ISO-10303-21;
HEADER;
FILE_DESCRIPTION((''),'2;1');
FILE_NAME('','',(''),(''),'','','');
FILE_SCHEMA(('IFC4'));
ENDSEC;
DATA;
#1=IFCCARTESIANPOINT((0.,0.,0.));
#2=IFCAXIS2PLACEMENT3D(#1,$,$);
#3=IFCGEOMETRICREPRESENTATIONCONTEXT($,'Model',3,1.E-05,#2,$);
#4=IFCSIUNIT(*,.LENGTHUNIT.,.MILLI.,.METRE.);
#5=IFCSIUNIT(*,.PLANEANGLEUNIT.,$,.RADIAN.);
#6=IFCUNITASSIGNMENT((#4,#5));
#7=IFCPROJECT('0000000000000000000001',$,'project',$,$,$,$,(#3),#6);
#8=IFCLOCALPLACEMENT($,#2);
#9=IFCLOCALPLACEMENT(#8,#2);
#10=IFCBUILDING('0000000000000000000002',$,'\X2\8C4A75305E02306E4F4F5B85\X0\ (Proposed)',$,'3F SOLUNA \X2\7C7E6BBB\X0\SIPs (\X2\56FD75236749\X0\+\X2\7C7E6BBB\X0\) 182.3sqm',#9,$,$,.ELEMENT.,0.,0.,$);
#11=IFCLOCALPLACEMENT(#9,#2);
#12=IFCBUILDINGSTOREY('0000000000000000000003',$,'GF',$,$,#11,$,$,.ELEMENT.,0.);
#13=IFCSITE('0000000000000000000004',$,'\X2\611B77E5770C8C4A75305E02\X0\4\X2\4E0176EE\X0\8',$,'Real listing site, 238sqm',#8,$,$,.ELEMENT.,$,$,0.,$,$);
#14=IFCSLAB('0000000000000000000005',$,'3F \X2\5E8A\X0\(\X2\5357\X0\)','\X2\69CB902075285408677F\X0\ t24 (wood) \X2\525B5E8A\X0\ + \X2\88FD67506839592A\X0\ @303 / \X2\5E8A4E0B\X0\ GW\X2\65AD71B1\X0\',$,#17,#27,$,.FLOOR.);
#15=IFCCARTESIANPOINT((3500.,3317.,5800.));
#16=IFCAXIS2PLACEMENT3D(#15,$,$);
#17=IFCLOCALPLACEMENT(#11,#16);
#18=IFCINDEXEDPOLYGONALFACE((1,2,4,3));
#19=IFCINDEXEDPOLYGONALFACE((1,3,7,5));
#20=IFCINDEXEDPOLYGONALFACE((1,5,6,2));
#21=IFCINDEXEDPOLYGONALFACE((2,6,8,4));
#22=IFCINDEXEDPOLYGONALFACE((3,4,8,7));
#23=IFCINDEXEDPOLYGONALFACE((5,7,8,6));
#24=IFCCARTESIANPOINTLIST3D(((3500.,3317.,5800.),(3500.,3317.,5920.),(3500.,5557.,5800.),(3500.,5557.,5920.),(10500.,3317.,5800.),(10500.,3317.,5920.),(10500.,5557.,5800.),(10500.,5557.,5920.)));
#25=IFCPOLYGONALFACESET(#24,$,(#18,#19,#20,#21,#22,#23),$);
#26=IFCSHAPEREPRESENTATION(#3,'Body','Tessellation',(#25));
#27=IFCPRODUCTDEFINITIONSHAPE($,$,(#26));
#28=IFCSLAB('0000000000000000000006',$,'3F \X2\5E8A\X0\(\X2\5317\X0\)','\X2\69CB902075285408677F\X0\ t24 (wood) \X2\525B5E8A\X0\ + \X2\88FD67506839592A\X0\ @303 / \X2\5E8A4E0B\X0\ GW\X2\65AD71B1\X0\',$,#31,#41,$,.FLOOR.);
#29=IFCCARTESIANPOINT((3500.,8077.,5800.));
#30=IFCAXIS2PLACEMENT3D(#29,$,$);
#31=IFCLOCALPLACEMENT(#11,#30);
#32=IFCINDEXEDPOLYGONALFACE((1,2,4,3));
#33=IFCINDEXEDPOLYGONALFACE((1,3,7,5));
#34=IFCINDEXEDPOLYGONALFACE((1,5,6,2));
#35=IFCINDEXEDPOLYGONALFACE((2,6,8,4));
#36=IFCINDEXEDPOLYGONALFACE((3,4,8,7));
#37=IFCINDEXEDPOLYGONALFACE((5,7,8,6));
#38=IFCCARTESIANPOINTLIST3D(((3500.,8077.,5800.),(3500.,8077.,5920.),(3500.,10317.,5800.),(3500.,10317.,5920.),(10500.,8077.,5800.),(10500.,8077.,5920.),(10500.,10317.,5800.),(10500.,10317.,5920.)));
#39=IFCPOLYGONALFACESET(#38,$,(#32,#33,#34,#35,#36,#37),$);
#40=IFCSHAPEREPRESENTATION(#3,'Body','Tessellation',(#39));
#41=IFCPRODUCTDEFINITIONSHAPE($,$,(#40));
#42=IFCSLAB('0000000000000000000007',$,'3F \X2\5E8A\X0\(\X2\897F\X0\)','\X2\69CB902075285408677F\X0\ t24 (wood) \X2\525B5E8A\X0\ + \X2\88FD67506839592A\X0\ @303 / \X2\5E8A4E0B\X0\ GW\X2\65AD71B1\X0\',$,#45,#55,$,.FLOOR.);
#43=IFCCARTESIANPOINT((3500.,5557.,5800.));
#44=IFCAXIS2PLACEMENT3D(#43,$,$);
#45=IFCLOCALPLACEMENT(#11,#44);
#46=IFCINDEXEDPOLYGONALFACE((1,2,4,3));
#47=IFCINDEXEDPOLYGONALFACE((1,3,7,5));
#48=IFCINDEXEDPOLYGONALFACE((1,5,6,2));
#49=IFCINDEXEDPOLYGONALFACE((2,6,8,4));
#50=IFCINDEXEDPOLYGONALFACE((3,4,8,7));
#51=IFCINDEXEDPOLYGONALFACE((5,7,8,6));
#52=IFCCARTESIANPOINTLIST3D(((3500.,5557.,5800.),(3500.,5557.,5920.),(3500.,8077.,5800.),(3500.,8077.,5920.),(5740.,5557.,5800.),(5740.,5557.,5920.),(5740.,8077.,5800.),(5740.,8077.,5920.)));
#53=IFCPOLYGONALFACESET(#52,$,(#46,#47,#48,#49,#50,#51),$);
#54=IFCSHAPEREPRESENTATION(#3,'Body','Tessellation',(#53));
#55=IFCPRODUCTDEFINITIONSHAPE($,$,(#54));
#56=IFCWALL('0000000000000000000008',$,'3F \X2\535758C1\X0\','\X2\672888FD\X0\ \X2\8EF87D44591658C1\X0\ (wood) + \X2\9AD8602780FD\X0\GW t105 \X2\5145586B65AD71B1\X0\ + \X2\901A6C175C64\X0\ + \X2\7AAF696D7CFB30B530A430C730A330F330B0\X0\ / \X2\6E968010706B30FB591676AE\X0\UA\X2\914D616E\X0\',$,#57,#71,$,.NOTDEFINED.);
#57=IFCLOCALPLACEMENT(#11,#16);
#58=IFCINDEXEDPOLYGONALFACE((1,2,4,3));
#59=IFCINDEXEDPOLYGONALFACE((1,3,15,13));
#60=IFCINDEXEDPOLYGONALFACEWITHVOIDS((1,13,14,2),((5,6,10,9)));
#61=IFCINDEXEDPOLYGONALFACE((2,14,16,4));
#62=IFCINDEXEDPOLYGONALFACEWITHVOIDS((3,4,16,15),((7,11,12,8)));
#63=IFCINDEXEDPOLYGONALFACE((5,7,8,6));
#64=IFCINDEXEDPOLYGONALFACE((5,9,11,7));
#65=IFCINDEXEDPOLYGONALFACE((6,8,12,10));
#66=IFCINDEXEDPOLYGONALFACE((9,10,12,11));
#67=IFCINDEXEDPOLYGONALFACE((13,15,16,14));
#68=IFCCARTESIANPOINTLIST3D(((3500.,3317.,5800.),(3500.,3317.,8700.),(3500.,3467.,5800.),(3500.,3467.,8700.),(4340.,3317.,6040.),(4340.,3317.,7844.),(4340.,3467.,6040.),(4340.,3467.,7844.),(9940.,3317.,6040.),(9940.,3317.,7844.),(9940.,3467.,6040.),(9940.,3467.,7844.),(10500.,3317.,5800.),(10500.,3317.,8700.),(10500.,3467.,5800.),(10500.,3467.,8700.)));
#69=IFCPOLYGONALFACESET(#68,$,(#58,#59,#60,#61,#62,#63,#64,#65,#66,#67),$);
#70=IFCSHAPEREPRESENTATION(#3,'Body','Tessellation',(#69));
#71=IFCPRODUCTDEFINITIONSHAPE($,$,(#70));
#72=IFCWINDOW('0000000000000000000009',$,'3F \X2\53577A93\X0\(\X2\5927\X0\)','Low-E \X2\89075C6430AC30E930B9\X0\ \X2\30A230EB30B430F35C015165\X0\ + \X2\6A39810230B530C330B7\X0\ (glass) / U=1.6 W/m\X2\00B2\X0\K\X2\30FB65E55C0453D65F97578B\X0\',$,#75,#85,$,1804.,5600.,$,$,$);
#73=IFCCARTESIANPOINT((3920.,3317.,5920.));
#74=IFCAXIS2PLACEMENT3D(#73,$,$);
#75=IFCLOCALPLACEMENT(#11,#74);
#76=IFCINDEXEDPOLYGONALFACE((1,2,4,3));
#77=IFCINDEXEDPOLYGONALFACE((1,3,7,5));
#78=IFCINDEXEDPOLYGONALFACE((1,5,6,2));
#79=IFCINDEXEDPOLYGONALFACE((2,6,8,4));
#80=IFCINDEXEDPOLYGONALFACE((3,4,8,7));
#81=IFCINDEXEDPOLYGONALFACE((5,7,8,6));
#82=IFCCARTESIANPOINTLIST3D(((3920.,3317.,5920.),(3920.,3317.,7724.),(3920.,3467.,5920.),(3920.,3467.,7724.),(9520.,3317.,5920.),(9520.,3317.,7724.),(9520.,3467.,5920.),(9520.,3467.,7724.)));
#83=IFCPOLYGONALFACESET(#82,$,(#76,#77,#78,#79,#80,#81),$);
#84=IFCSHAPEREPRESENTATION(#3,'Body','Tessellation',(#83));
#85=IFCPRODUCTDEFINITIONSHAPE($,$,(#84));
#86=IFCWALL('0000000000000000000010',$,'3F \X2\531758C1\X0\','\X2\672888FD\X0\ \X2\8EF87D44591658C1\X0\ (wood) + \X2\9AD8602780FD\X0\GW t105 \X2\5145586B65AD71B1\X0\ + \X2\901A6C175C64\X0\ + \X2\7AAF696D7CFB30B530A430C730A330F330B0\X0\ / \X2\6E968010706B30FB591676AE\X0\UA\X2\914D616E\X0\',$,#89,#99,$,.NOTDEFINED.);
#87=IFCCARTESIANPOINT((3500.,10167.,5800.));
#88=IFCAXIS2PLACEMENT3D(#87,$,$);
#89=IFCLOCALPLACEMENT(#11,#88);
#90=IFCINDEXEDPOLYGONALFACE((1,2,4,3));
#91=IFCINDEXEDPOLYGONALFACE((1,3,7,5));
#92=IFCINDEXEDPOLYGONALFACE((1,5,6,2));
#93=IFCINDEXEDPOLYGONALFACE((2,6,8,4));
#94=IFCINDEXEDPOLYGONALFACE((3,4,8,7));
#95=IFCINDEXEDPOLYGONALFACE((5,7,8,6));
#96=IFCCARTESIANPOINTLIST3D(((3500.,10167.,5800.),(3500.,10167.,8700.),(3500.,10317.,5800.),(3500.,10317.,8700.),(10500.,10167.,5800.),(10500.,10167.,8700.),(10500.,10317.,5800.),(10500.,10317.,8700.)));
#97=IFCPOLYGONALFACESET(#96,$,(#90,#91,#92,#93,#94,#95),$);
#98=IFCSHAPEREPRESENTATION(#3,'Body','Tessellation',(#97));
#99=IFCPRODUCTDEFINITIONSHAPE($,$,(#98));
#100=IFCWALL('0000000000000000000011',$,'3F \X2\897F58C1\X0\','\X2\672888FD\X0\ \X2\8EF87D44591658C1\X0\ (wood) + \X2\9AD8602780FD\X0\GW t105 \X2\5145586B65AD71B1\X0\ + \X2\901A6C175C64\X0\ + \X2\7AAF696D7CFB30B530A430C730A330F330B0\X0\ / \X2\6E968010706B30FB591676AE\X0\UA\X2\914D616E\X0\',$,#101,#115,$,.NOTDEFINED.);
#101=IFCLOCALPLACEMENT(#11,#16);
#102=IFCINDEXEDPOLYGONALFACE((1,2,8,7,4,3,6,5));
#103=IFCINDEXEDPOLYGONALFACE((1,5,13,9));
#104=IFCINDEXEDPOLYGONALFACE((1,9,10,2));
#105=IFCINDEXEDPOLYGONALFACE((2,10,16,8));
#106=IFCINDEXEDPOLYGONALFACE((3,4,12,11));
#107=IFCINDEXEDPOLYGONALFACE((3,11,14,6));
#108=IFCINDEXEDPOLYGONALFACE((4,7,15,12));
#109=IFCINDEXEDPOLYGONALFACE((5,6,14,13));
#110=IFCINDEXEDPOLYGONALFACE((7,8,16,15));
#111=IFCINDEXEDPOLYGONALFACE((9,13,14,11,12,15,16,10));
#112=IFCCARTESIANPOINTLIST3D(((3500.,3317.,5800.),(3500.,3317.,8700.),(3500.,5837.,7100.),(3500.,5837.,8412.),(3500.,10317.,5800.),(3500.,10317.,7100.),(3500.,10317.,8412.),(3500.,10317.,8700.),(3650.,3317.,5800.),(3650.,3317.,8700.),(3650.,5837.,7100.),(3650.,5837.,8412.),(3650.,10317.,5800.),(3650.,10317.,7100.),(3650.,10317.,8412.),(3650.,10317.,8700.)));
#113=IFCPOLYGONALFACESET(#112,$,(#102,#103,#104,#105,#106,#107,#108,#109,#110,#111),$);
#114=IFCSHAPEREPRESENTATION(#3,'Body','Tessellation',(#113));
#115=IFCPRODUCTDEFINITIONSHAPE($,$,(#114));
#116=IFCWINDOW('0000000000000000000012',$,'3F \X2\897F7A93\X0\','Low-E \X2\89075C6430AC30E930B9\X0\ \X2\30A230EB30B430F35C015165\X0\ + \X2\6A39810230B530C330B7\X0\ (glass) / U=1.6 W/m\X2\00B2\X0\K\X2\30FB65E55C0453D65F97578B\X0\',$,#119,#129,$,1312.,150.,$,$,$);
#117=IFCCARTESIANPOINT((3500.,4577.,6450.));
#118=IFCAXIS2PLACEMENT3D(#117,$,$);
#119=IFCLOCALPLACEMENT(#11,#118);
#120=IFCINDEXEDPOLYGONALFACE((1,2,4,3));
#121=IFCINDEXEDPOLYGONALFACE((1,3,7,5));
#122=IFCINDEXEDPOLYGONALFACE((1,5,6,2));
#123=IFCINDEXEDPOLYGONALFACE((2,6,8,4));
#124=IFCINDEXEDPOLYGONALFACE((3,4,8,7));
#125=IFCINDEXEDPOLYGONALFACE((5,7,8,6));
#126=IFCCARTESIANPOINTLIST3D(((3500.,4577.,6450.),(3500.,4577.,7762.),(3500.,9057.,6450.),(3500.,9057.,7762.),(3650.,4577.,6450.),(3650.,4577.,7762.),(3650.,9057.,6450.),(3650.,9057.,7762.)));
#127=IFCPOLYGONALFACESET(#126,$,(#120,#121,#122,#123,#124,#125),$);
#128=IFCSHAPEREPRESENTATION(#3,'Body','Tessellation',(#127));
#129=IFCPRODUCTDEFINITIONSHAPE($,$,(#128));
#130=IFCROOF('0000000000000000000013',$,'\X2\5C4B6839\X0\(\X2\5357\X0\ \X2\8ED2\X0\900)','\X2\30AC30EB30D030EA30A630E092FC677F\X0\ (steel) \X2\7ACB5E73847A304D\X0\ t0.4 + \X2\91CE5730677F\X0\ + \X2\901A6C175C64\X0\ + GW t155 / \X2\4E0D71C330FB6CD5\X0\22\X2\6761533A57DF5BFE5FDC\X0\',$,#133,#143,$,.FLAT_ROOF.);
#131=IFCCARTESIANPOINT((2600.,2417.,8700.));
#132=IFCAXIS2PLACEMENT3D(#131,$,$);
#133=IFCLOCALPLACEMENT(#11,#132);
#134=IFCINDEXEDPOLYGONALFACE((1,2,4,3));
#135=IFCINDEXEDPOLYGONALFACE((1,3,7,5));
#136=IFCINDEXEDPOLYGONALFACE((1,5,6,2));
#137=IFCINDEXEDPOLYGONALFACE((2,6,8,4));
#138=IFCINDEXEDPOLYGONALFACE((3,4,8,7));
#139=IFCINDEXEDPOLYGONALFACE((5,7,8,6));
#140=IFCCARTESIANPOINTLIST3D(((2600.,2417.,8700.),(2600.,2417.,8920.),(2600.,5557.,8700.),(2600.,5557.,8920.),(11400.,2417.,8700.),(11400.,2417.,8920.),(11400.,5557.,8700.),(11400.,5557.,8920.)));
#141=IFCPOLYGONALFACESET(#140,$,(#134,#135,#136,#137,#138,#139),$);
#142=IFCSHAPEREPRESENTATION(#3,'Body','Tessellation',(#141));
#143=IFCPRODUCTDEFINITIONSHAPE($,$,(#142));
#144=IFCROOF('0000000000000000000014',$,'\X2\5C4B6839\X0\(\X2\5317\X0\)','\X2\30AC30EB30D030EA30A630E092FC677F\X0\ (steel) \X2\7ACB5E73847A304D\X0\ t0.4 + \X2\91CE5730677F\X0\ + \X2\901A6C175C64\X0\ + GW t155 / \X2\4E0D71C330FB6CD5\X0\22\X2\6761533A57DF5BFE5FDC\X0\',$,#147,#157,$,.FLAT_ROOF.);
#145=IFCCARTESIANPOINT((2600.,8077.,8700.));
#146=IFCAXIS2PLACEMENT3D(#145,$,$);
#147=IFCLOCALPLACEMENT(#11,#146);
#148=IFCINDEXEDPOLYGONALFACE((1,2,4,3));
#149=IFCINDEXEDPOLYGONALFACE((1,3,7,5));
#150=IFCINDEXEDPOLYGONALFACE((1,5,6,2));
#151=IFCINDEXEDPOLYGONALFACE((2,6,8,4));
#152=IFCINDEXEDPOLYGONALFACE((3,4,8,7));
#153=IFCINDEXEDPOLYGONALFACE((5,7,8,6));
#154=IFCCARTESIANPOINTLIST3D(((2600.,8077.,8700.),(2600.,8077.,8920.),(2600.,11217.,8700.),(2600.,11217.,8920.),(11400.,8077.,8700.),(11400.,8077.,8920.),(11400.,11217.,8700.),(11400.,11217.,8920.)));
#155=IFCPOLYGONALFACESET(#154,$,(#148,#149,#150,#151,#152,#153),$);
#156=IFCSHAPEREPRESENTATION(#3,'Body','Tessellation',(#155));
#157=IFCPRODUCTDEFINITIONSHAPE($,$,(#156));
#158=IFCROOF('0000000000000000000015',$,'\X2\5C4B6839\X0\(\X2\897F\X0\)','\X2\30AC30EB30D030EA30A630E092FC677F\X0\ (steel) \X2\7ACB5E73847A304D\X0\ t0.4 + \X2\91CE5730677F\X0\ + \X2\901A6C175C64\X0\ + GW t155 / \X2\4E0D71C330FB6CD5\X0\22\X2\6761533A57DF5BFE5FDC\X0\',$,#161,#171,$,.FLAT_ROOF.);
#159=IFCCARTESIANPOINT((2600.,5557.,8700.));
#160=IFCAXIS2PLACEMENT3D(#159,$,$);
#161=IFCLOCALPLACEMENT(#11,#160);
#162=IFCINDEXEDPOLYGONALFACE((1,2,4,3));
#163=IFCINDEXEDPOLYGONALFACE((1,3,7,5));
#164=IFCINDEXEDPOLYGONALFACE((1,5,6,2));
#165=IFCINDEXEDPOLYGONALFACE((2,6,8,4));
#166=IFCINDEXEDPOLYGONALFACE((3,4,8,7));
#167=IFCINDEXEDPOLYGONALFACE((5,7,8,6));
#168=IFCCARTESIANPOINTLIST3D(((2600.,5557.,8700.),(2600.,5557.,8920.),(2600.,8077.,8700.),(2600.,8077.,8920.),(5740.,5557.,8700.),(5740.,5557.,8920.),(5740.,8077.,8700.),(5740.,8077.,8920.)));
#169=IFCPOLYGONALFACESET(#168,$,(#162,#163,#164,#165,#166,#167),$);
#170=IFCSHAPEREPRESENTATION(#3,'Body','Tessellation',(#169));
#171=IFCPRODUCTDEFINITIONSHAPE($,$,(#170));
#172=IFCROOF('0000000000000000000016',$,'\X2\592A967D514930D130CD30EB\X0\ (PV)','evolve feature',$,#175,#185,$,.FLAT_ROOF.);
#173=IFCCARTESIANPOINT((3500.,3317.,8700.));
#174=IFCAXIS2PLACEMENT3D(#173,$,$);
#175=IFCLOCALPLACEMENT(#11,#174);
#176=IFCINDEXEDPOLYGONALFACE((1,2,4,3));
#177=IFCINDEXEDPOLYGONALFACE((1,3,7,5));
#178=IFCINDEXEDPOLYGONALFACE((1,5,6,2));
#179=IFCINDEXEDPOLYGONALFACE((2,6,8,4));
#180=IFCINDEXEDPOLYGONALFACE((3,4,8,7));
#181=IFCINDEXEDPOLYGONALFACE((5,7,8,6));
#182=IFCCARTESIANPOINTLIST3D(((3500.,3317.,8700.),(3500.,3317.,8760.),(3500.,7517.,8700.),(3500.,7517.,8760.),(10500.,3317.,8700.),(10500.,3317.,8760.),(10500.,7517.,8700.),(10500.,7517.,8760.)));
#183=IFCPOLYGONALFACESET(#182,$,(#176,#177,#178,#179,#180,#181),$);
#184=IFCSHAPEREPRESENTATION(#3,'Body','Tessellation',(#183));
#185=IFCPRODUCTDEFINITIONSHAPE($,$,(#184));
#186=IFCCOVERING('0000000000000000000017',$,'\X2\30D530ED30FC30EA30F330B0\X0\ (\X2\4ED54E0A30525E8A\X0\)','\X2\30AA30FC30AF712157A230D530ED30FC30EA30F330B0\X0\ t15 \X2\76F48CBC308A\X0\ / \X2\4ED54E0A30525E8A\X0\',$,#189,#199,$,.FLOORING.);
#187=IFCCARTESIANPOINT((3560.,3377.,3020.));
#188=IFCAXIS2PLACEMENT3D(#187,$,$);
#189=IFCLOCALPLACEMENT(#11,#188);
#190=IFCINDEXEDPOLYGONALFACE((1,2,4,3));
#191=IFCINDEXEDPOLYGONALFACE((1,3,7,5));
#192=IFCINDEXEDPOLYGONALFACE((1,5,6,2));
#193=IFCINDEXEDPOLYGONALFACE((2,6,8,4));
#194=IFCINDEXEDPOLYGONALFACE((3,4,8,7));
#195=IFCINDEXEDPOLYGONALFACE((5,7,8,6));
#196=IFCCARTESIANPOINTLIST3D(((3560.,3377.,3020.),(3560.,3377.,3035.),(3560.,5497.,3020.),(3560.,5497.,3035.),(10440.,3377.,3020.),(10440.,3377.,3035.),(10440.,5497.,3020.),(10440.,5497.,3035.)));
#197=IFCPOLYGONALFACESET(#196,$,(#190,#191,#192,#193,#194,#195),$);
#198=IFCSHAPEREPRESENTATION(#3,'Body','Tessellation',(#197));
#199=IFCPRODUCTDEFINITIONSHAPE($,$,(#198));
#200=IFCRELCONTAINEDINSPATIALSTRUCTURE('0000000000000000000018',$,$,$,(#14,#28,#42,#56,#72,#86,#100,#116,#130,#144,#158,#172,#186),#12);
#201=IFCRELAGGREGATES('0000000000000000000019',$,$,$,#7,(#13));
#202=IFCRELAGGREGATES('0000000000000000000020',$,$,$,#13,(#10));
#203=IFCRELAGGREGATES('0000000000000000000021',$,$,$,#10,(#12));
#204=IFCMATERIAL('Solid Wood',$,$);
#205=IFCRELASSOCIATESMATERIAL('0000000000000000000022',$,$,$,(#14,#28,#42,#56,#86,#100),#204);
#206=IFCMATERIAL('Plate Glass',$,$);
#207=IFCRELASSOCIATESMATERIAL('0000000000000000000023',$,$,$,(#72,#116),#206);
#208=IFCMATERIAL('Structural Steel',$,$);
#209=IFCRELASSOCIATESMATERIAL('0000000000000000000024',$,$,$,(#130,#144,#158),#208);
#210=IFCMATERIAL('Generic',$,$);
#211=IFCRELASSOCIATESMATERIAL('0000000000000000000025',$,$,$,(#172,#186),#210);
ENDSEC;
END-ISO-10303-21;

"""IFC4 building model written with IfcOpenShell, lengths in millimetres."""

from ifc_helpers import new_model, si_unit, frame, frame_2d, origin, place, context, project, spatial, rectangle, extrude, material, element, fill, save


model = new_model("IFC4")

# Units and contexts
model_context = context("Model", 3, precision=1e-05, world=origin())
ifc_project = project(units=[si_unit("LENGTHUNIT", "METRE", prefix="MILLI"), si_unit("PLANEANGLEUNIT", "RADIAN")], contexts=[model_context])

# Site, building, storey
site_placement = place(None, origin())
site = spatial("IfcSite", under=ifc_project, at=site_placement, Name="愛知県豊田市4丁目8", ObjectType="Real listing site, 238sqm", CompositionType="ELEMENT", RefElevation=0.0)
building_placement = place(site_placement, origin())
building = spatial("IfcBuilding", under=site, at=building_placement, Name="豊田市の住宅 (Proposed)", ObjectType="3F SOLUNA 籾殻SIPs (国産杉+籾殻) 182.3sqm", CompositionType="ELEMENT", ElevationOfRefHeight=0.0, ElevationOfTerrain=0.0)
storey_placement = place(building_placement, origin())
storey = spatial("IfcBuildingStorey", under=building, at=storey_placement, Name="GF", CompositionType="ELEMENT", Elevation=0.0)

# Slabs
ifc_material_1 = material(Name="Solid Wood")
slab_1_placement = place(storey_placement, frame((3500.0, 3317.0, 5800.0)))
element("IfcSlab", 1, at=slab_1_placement, inside=storey, material=ifc_material_1, Name="3F 床(南)", Description="構造用合板 t24 (wood) 剛床 + 製材根太 @303 / 床下 GW断熱", PredefinedType="FLOOR", context=model_context, shape_type="SweptSolid", body=[
    extrude(rectangle(XDim=7000.0, YDim=2240.0, at=frame_2d((3500.0, 1120.0))), frame((3500.0, 3317.0, 5800.0)), (0.0, 0.0, 1.0), 120.0),
])
slab_2_placement = place(storey_placement, frame((3500.0, 8077.0, 5800.0)))
element("IfcSlab", 2, at=slab_2_placement, inside=storey, material=ifc_material_1, Name="3F 床(北)", Description="構造用合板 t24 (wood) 剛床 + 製材根太 @303 / 床下 GW断熱", PredefinedType="FLOOR", context=model_context, shape_type="SweptSolid", body=[
    extrude(rectangle(XDim=7000.0, YDim=2240.0, at=frame_2d((3500.0, 1120.0))), frame((3500.0, 8077.0, 5800.0)), (0.0, 0.0, 1.0), 120.0),
])
slab_3_placement = place(storey_placement, frame((3500.0, 5557.0, 5800.0)))
element("IfcSlab", 3, at=slab_3_placement, inside=storey, material=ifc_material_1, Name="3F 床(西)", Description="構造用合板 t24 (wood) 剛床 + 製材根太 @303 / 床下 GW断熱", PredefinedType="FLOOR", context=model_context, shape_type="SweptSolid", body=[
    extrude(rectangle(XDim=2240.0, YDim=2520.0, at=frame_2d((1120.0, 1260.0))), frame((3500.0, 5557.0, 5800.0)), (0.0, 0.0, 1.0), 120.0),
])

# Wall, opening, window
wall_1_placement = place(storey_placement, frame((3500.0, 3317.0, 5800.0)))
wall_1 = element("IfcWall", 4, at=wall_1_placement, inside=storey, material=ifc_material_1, Name="3F 南壁", Description="木製 軸組外壁 (wood) + 高性能GW t105 充填断熱 + 通気層 + 窯業系サイディング / 準耐火・外皮UA配慮", PredefinedType="NOTDEFINED", context=model_context, shape_type="SweptSolid", body=[
    extrude(rectangle(XDim=7000.0, YDim=150.0, at=frame_2d((3500.0, 75.0))), frame((3500.0, 3317.0, 5800.0)), (0.0, 0.0, 1.0), 2900.0),
])
opening_1_placement = place(storey_placement, frame((3920.0, 3317.0, 5920.0)))
opening_1 = element("IfcOpeningElement", 5, at=opening_1_placement, cuts=wall_1, PredefinedType="NOTDEFINED", context=model_context, shape_type="SweptSolid", body=[
    extrude(rectangle(XDim=5600.0, YDim=150.0, at=frame_2d((2800.0, 75.0))), frame((3920.0, 3317.0, 5920.0)), (0.0, 0.0, 1.0), 1804.0),
])
ifc_material_2 = material(Name="Plate Glass")
window_1_placement = place(storey_placement, frame((3920.0, 3317.0, 5920.0)))
window_1 = element("IfcWindow", 6, at=window_1_placement, inside=storey, material=ifc_material_2, Name="3F 南窓(大)", Description="Low-E 複層ガラス アルゴン封入 + 樹脂サッシ (glass) / U=1.6 W/m²K・日射取得型", OverallHeight=1804.0, OverallWidth=5600.0, context=model_context, shape_type="SweptSolid", body=[
    extrude(rectangle(XDim=5600.0, YDim=150.0, at=frame_2d((2800.0, 75.0))), frame((3920.0, 3317.0, 5920.0)), (0.0, 0.0, 1.0), 1804.0),
])
fill(opening_1, window_1)

# Wall
wall_2_placement = place(storey_placement, frame((3500.0, 10167.0, 5800.0)))
element("IfcWall", 7, at=wall_2_placement, inside=storey, material=ifc_material_1, Name="3F 北壁", Description="木製 軸組外壁 (wood) + 高性能GW t105 充填断熱 + 通気層 + 窯業系サイディング / 準耐火・外皮UA配慮", PredefinedType="NOTDEFINED", context=model_context, shape_type="SweptSolid", body=[
    extrude(rectangle(XDim=7000.0, YDim=150.0, at=frame_2d((3500.0, 75.0))), frame((3500.0, 10167.0, 5800.0)), (0.0, 0.0, 1.0), 2900.0),
])

# Wall, opening, window
wall_3_placement = place(storey_placement, frame((3500.0, 3317.0, 5800.0)))
wall_3 = element("IfcWall", 8, at=wall_3_placement, inside=storey, material=ifc_material_1, Name="3F 西壁", Description="木製 軸組外壁 (wood) + 高性能GW t105 充填断熱 + 通気層 + 窯業系サイディング / 準耐火・外皮UA配慮", PredefinedType="NOTDEFINED", context=model_context, shape_type="SweptSolid", body=[
    extrude(rectangle(XDim=150.0, YDim=7000.0, at=frame_2d((75.0, 3500.0))), frame((3500.0, 3317.0, 5800.0)), (0.0, 0.0, 1.0), 2900.0),
])
opening_2_placement = place(storey_placement, frame((3500.0, 4577.0, 6450.0)))
opening_2 = element("IfcOpeningElement", 9, at=opening_2_placement, cuts=wall_3, PredefinedType="NOTDEFINED", context=model_context, shape_type="SweptSolid", body=[
    extrude(rectangle(XDim=150.0, YDim=4480.0, at=frame_2d((75.0, 2240.0))), frame((3500.0, 4577.0, 6450.0)), (0.0, 0.0, 1.0), 1312.0),
])
window_2_placement = place(storey_placement, frame((3500.0, 4577.0, 6450.0)))
window_2 = element("IfcWindow", 10, at=window_2_placement, inside=storey, material=ifc_material_2, Name="3F 西窓", Description="Low-E 複層ガラス アルゴン封入 + 樹脂サッシ (glass) / U=1.6 W/m²K・日射取得型", OverallHeight=1312.0, OverallWidth=150.0, context=model_context, shape_type="SweptSolid", body=[
    extrude(rectangle(XDim=150.0, YDim=4480.0, at=frame_2d((75.0, 2240.0))), frame((3500.0, 4577.0, 6450.0)), (0.0, 0.0, 1.0), 1312.0),
])
fill(opening_2, window_2)

# Roofs
ifc_material_3 = material(Name="Structural Steel")
roof_1_placement = place(storey_placement, frame((2600.0, 2417.0, 8700.0)))
element("IfcRoof", 11, at=roof_1_placement, inside=storey, material=ifc_material_3, Name="屋根(南 軒900)", Description="ガルバリウム鋼板 (steel) 立平葺き t0.4 + 野地板 + 通気層 + GW t155 / 不燃・法22条区域対応", PredefinedType="FLAT_ROOF", context=model_context, shape_type="SweptSolid", body=[
    extrude(rectangle(XDim=8800.0, YDim=3140.0, at=frame_2d((4400.0, 1570.0))), frame((2600.0, 2417.0, 8700.0)), (0.0, 0.0, 1.0), 220.0),
])
roof_2_placement = place(storey_placement, frame((2600.0, 8077.0, 8700.0)))
element("IfcRoof", 12, at=roof_2_placement, inside=storey, material=ifc_material_3, Name="屋根(北)", Description="ガルバリウム鋼板 (steel) 立平葺き t0.4 + 野地板 + 通気層 + GW t155 / 不燃・法22条区域対応", PredefinedType="FLAT_ROOF", context=model_context, shape_type="SweptSolid", body=[
    extrude(rectangle(XDim=8800.0, YDim=3140.0, at=frame_2d((4400.0, 1570.0))), frame((2600.0, 8077.0, 8700.0)), (0.0, 0.0, 1.0), 220.0),
])
roof_3_placement = place(storey_placement, frame((2600.0, 5557.0, 8700.0)))
element("IfcRoof", 13, at=roof_3_placement, inside=storey, material=ifc_material_3, Name="屋根(西)", Description="ガルバリウム鋼板 (steel) 立平葺き t0.4 + 野地板 + 通気層 + GW t155 / 不燃・法22条区域対応", PredefinedType="FLAT_ROOF", context=model_context, shape_type="SweptSolid", body=[
    extrude(rectangle(XDim=3140.0, YDim=2520.0, at=frame_2d((1570.0, 1260.0))), frame((2600.0, 5557.0, 8700.0)), (0.0, 0.0, 1.0), 220.0),
])
ifc_material_4 = material(Name="Generic")
roof_4_placement = place(storey_placement, frame((3500.0, 3317.0, 8700.0)))
element("IfcRoof", 14, at=roof_4_placement, inside=storey, material=ifc_material_4, Name="太陽光パネル (PV)", Description="evolve feature", PredefinedType="FLAT_ROOF", context=model_context, shape_type="SweptSolid", body=[
    extrude(rectangle(XDim=7000.0, YDim=4200.0, at=frame_2d((3500.0, 2100.0))), frame((3500.0, 3317.0, 8700.0)), (0.0, 0.0, 1.0), 60.0),
])

# Covering
covering_1_placement = place(storey_placement, frame((3560.0, 3377.0, 3020.0)))
element("IfcCovering", 15, at=covering_1_placement, inside=storey, material=ifc_material_4, Name="フローリング (仕上げ床)", Description="オーク無垢フローリング t15 直貼り / 仕上げ床", PredefinedType="FLOORING", context=model_context, shape_type="SweptSolid", body=[
    extrude(rectangle(XDim=6880.0, YDim=2120.0, at=frame_2d((3440.0, 1060.0))), frame((3560.0, 3377.0, 3020.0)), (0.0, 0.0, 1.0), 15.0),
])

save(model, "model.ifc")
